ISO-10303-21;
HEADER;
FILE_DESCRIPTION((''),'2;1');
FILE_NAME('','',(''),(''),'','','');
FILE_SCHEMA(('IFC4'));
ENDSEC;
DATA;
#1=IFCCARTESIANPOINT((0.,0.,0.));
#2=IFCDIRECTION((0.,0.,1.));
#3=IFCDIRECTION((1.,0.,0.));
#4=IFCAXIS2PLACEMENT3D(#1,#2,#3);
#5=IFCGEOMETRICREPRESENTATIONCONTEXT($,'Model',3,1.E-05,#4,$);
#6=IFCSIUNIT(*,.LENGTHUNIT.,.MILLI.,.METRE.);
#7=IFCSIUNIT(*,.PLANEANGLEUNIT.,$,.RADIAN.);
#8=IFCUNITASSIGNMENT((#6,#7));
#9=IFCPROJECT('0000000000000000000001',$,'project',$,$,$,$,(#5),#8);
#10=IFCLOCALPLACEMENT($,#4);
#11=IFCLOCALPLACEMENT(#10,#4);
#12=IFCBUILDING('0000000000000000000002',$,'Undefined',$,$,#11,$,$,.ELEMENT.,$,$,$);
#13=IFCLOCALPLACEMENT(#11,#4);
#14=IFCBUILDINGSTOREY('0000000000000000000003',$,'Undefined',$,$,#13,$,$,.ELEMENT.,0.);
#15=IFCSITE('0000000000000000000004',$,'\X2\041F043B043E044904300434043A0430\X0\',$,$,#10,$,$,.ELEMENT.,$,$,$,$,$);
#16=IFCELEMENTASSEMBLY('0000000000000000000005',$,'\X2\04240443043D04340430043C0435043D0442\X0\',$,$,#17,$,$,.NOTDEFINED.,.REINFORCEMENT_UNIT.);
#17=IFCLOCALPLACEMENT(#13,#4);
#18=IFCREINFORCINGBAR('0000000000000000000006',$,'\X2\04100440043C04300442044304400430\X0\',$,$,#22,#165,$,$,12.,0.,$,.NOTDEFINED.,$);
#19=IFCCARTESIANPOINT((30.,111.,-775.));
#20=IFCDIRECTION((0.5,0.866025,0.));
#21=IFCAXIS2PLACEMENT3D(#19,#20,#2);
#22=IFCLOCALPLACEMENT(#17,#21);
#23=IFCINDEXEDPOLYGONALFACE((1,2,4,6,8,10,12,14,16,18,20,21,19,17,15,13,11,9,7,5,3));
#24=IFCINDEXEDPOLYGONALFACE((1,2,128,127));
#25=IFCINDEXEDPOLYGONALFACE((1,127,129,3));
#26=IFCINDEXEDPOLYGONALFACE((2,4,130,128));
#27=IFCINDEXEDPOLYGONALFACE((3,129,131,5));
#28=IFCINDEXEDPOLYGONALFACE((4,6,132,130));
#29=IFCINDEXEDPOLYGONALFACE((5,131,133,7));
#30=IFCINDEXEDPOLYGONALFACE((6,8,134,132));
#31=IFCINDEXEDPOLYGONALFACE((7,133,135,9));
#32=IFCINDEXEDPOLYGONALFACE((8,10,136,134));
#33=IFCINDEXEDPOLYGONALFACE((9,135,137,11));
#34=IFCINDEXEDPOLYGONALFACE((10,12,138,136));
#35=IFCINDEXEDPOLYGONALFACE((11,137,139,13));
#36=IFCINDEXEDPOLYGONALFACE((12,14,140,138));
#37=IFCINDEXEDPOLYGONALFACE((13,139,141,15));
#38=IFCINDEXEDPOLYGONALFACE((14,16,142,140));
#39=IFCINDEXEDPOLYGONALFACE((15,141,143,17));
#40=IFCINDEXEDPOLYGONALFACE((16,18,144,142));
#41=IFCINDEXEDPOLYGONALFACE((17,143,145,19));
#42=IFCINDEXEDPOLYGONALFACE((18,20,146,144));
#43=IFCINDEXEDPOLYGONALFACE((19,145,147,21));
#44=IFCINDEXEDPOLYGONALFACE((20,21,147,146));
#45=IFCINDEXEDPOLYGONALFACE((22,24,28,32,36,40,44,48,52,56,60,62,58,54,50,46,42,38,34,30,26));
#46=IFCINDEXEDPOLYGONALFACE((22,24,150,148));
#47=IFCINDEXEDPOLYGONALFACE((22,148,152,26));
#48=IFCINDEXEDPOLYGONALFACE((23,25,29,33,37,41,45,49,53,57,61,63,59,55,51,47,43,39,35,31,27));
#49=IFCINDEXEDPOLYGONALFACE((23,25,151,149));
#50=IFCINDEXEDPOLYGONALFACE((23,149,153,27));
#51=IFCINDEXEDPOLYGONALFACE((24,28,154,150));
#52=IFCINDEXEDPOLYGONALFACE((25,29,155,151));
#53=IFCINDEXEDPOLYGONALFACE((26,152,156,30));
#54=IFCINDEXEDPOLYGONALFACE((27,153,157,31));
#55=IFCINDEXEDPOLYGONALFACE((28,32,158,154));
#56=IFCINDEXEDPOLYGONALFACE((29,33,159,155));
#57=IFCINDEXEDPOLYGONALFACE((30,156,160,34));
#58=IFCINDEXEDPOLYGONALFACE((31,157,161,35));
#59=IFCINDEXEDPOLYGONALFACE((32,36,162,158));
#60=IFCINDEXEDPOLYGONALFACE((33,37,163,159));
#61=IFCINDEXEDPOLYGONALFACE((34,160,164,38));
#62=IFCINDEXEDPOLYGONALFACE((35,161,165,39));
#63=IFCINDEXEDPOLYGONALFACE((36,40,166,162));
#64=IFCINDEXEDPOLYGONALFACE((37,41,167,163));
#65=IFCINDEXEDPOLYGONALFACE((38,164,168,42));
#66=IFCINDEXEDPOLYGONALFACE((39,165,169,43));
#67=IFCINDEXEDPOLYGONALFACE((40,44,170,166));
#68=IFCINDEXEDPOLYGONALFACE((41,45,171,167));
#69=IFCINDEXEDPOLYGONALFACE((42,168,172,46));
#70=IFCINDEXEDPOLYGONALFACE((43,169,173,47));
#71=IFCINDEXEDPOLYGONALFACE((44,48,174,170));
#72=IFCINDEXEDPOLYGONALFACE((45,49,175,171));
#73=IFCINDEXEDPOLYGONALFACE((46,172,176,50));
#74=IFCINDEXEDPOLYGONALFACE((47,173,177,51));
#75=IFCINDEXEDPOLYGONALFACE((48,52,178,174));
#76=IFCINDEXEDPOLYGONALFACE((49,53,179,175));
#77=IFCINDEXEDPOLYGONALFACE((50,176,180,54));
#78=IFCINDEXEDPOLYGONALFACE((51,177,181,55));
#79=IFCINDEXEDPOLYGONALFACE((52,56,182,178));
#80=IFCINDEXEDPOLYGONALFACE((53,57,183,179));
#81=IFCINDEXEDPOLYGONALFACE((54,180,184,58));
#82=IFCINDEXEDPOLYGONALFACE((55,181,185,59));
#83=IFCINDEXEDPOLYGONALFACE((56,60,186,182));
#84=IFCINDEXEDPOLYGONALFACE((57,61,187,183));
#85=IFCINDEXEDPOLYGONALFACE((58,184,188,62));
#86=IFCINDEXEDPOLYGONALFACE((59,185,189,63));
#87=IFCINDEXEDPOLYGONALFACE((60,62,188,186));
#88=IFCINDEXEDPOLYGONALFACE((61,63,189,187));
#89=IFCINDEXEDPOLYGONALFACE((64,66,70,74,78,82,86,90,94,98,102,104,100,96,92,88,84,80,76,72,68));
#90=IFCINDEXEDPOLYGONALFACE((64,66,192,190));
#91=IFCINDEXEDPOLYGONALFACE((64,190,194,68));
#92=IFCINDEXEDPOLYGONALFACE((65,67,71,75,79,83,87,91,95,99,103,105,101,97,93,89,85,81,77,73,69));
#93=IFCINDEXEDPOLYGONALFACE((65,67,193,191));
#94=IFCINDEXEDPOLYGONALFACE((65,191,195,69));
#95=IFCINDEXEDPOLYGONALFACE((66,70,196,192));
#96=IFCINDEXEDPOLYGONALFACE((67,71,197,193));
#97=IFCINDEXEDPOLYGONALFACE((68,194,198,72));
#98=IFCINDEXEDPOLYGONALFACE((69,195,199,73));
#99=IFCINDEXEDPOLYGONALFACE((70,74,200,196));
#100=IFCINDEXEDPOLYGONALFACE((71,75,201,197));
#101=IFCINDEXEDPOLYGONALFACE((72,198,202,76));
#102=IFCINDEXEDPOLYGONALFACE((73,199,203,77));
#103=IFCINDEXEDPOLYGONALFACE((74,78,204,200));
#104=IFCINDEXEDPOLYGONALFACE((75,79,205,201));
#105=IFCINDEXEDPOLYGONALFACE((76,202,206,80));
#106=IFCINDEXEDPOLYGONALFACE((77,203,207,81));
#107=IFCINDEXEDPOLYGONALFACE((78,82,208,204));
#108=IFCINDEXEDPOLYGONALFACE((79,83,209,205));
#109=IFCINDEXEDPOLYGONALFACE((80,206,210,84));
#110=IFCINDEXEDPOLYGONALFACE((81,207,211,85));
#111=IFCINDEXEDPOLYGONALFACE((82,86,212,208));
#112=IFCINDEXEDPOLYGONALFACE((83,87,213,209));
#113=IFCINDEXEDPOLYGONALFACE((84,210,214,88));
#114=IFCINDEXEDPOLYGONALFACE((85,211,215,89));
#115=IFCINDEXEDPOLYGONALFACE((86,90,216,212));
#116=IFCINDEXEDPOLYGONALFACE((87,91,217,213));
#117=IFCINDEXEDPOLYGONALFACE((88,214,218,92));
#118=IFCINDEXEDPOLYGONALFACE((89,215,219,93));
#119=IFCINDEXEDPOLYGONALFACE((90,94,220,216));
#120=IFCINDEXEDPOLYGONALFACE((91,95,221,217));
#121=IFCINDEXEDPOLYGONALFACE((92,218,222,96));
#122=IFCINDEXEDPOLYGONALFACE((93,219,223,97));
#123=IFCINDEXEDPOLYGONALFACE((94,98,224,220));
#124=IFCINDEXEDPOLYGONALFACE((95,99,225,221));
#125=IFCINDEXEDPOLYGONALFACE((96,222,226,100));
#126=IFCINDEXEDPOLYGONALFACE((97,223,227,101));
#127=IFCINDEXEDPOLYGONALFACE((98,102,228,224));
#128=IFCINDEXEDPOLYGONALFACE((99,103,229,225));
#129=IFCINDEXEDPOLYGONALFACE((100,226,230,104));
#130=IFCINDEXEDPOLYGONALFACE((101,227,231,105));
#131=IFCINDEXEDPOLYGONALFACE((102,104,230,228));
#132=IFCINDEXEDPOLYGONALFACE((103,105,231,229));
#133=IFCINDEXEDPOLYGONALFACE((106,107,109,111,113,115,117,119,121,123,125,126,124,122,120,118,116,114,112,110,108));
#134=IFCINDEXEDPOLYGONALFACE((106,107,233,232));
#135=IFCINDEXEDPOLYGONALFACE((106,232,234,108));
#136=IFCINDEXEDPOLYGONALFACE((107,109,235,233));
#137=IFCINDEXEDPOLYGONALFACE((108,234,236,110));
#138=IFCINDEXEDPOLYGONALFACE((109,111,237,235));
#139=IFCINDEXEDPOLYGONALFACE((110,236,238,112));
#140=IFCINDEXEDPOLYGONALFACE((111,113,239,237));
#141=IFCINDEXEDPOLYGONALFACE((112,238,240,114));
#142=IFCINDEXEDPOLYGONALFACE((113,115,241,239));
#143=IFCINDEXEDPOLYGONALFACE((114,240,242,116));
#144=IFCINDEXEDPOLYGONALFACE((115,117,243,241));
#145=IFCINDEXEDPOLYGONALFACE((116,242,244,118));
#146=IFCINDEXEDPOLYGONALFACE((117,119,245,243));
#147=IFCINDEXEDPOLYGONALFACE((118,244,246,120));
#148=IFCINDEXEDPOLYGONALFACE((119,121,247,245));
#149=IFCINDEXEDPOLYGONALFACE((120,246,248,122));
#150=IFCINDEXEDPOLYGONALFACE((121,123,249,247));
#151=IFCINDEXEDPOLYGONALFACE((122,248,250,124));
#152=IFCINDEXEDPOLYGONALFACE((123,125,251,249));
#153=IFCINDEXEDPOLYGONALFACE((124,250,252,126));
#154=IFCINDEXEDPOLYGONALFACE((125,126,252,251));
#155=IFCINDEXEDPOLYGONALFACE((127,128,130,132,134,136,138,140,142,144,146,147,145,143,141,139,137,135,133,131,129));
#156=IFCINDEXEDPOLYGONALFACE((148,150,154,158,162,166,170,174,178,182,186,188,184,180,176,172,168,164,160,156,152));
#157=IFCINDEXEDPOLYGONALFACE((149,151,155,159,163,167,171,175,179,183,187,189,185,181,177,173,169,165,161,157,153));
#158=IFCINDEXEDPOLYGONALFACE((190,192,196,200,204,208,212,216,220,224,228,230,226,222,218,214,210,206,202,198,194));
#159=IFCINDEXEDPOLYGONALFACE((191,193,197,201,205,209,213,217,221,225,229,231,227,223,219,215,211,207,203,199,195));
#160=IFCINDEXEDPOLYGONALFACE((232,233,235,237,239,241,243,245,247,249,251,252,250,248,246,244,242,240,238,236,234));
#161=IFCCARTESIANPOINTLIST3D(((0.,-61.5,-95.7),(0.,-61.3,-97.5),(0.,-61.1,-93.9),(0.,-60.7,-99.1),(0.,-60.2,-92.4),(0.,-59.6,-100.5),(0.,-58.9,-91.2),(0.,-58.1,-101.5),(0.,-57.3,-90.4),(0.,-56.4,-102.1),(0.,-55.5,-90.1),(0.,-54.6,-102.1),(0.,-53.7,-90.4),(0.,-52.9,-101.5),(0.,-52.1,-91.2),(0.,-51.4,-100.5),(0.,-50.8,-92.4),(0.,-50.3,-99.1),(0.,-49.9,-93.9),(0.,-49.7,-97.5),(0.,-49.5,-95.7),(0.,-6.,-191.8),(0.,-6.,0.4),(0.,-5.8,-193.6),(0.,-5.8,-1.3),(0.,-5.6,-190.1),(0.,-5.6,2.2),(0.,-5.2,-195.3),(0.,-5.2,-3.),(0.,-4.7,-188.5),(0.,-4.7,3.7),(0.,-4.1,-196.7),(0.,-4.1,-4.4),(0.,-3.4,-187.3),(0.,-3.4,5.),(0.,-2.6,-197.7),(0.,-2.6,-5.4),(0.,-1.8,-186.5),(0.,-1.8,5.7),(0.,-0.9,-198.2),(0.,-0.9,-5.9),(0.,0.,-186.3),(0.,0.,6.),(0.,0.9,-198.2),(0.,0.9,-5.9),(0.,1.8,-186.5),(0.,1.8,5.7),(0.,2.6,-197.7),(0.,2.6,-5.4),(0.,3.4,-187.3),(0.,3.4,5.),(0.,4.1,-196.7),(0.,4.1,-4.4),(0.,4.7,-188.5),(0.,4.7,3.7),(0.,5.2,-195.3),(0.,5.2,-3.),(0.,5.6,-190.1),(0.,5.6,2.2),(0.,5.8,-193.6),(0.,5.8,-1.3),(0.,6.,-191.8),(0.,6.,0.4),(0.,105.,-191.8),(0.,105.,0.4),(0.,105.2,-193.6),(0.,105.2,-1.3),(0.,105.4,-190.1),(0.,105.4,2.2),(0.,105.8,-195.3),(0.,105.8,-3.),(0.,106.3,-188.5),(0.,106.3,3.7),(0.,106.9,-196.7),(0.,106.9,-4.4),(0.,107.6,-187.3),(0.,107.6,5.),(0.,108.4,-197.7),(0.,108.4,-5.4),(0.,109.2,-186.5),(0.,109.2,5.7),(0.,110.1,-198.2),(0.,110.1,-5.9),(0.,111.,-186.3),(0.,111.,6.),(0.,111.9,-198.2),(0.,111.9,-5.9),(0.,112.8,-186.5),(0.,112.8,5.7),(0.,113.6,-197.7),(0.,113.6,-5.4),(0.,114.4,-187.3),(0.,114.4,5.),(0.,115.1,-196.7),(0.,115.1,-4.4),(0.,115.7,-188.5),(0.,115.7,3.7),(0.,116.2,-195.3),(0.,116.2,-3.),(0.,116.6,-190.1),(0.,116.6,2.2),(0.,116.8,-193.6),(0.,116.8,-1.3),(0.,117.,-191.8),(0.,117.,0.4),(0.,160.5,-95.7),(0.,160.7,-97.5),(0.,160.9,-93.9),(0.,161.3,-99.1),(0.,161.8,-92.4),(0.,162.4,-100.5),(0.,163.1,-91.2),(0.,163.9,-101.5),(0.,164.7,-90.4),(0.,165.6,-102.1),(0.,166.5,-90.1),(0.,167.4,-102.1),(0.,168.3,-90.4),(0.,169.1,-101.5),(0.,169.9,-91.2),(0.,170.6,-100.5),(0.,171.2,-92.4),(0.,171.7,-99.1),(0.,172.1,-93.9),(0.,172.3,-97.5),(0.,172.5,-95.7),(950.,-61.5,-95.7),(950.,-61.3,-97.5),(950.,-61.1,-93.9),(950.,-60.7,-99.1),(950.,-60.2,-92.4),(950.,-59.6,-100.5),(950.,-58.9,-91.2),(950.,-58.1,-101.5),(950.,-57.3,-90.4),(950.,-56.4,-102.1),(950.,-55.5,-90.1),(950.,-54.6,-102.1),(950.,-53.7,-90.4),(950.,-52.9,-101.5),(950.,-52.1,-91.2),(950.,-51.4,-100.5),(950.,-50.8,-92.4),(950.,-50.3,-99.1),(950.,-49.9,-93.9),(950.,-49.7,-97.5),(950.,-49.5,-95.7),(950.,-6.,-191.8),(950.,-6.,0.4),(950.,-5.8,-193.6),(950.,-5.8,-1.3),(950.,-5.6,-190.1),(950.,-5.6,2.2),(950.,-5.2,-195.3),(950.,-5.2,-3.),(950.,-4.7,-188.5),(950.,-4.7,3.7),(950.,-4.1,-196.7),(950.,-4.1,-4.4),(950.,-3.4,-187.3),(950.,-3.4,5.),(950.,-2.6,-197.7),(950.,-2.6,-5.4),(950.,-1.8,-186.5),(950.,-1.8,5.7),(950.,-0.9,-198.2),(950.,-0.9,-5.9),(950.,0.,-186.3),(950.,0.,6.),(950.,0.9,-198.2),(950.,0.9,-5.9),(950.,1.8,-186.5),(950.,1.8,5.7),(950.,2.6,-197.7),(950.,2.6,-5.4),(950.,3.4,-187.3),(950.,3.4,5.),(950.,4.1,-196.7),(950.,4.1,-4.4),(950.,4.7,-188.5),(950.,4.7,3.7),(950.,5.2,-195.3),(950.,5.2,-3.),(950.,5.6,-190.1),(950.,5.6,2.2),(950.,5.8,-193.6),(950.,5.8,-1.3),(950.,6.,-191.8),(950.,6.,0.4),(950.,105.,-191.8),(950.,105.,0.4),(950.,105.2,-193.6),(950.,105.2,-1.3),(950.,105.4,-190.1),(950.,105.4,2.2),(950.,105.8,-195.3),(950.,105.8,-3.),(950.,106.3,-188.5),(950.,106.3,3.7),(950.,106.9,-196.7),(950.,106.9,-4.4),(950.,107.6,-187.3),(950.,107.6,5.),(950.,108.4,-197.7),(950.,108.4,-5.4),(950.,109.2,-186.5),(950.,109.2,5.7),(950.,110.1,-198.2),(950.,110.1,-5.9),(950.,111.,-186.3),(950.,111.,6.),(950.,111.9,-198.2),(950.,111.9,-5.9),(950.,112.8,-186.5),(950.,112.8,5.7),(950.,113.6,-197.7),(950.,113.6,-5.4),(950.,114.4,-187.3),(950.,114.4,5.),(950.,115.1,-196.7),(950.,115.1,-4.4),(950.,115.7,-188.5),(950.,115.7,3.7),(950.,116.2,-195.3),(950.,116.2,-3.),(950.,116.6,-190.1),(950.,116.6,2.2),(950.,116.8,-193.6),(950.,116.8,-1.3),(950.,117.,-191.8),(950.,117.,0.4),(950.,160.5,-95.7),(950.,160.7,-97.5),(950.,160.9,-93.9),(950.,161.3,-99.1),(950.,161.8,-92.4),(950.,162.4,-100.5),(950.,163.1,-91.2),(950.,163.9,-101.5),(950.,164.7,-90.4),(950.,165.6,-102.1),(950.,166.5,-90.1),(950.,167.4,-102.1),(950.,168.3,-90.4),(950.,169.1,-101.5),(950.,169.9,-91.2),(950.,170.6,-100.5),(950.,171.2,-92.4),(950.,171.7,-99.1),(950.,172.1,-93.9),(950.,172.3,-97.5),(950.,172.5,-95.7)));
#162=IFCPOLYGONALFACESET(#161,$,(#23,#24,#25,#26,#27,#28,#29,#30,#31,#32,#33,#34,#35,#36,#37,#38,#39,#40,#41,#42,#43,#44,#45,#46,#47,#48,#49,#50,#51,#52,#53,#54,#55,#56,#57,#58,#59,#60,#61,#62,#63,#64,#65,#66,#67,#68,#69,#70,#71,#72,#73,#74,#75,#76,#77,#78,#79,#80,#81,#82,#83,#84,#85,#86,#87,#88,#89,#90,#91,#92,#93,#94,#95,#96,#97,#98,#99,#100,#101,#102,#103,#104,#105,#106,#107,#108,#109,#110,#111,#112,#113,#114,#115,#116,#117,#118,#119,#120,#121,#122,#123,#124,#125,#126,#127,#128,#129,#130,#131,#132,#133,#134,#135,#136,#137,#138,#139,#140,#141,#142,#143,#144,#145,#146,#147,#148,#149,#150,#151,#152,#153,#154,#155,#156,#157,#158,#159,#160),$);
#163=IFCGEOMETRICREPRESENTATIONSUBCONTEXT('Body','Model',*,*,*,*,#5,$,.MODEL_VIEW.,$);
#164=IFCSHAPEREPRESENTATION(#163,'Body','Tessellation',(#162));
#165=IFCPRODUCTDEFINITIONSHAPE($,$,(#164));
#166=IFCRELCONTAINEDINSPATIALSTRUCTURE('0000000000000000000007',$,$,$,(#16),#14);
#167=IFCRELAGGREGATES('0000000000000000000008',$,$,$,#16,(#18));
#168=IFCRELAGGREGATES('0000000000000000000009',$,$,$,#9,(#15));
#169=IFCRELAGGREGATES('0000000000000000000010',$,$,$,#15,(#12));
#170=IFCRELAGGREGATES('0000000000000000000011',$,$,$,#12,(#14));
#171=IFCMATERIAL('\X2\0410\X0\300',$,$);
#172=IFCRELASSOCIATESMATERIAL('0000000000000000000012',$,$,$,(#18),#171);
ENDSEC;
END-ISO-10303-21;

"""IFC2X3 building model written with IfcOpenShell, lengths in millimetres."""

from ifc_helpers import new_model, entity, si_unit, frame, origin_with_axes, place, context, subcontext, project, spatial, source, transform, mapped, material, element, aggregate, save


model = new_model("IFC2X3")

# Units and contexts
model_context = context("Model", 3, precision=1e-05, world=origin_with_axes())
body_context = subcontext(model_context, "Body", "Model", "MODEL_VIEW")
ifc_project = project(units=[si_unit("LENGTHUNIT", "METRE", prefix="MILLI"), si_unit("PLANEANGLEUNIT", "RADIAN")], contexts=[model_context])

# Site, building, storey
site_placement = place(None, origin_with_axes())
site = spatial("IfcSite", under=ifc_project, at=site_placement, Name="Площадка", CompositionType="ELEMENT")
building_placement = place(site_placement, origin_with_axes())
building = spatial("IfcBuilding", under=site, at=building_placement, Name="Undefined", CompositionType="ELEMENT")
storey_placement = place(building_placement, origin_with_axes())
storey = spatial("IfcBuildingStorey", under=building, at=storey_placement, Name="Undefined", CompositionType="ELEMENT", Elevation=0.0)

# Element assembly
assembly_1_placement = place(storey_placement, origin_with_axes())
assembly_1 = element("IfcElementAssembly", 1, at=assembly_1_placement, inside=storey, Name="Фундамент", AssemblyPlace="NOTDEFINED", PredefinedType="REINFORCEMENT_UNIT")

# Shared definitions
ifc_material_1 = material(Name="А300")

# Reinforcing bar
shared_shape_1 = source(origin_with_axes(), body_context, "Body", "AdvancedSweptSolid", [
    entity("IfcSweptDiskSolid", entity("IfcTrimmedCurve", entity("IfcLine", entity("IfcCartesianPoint", [0.0, 0.0, 0.0]), entity("IfcVector", entity("IfcDirection", [1.0, 0.0, 0.0]), 1.0)), [entity("IfcParameterValue", 0.0)], [entity("IfcParameterValue", 950.0)], True, "PARAMETER"), 6.0, None, 0.0, 950.0),
])
shared_shape_2 = source(origin_with_axes(), body_context, "Body", "AdvancedSweptSolid", [
    entity("IfcSweptDiskSolid", entity("IfcTrimmedCurve", entity("IfcLine", entity("IfcCartesianPoint", [0.0, 0.0, 0.0]), entity("IfcVector", entity("IfcDirection", [1.0, 0.0, 0.0]), 1.0)), [entity("IfcParameterValue", 0.0)], [entity("IfcParameterValue", 950.0)], True, "PARAMETER"), 6.0, None, 0.0, 950.0),
])
shared_shape_3 = source(origin_with_axes(), body_context, "Body", "AdvancedSweptSolid", [
    entity("IfcSweptDiskSolid", entity("IfcTrimmedCurve", entity("IfcLine", entity("IfcCartesianPoint", [0.0, 0.0, 0.0]), entity("IfcVector", entity("IfcDirection", [1.0, 0.0, 0.0]), 1.0)), [entity("IfcParameterValue", 0.0)], [entity("IfcParameterValue", 950.0)], True, "PARAMETER"), 6.0, None, 0.0, 950.0),
])
shared_shape_4 = source(origin_with_axes(), body_context, "Body", "AdvancedSweptSolid", [
    entity("IfcSweptDiskSolid", entity("IfcTrimmedCurve", entity("IfcLine", entity("IfcCartesianPoint", [0.0, 0.0, 0.0]), entity("IfcVector", entity("IfcDirection", [1.0, 0.0, 0.0]), 1.0)), [entity("IfcParameterValue", 0.0)], [entity("IfcParameterValue", 950.0)], True, "PARAMETER"), 6.0, None, 0.0, 950.0),
])
shared_shape_5 = source(origin_with_axes(), body_context, "Body", "AdvancedSweptSolid", [
    entity("IfcSweptDiskSolid", entity("IfcTrimmedCurve", entity("IfcLine", entity("IfcCartesianPoint", [0.0, 0.0, 0.0]), entity("IfcVector", entity("IfcDirection", [1.0, 0.0, 0.0]), 1.0)), [entity("IfcParameterValue", 0.0)], [entity("IfcParameterValue", 950.0)], True, "PARAMETER"), 6.0, None, 0.0, 950.0),
])
shared_shape_6 = source(origin_with_axes(), body_context, "Body", "AdvancedSweptSolid", [
    entity("IfcSweptDiskSolid", entity("IfcTrimmedCurve", entity("IfcLine", entity("IfcCartesianPoint", [0.0, 0.0, 0.0]), entity("IfcVector", entity("IfcDirection", [1.0, 0.0, 0.0]), 1.0)), [entity("IfcParameterValue", 0.0)], [entity("IfcParameterValue", 950.0)], True, "PARAMETER"), 6.0, None, 0.0, 950.0),
])
reinforcing_bar_1_placement = place(assembly_1_placement, frame((30.0, 111.0, -775.0), z_axis=(0.5, 0.866025, 0.0), x_axis=(0.0, 0.0, 1.0)))
reinforcing_bar_1 = element("IfcReinforcingBar", 2, at=reinforcing_bar_1_placement, material=ifc_material_1, Name="Арматура", BarRole="NOTDEFINED", CrossSectionArea=0.0, NominalDiameter=12.0, context=body_context, shape_type="MappedRepresentation", body=[
    mapped(shared_shape_1, transform((0.0, 0.0, 0.0))),
    mapped(shared_shape_2, transform((0.0, -55.5, -96.1))),
    mapped(shared_shape_3, transform((0.0, 0.0, -192.3))),
    mapped(shared_shape_4, transform((0.0, 111.0, -192.3))),
    mapped(shared_shape_5, transform((0.0, 166.5, -96.1))),
    mapped(shared_shape_6, transform((0.0, 111.0, 0.0))),
])
aggregate(assembly_1, [reinforcing_bar_1])

save(model, "model.ifc")
